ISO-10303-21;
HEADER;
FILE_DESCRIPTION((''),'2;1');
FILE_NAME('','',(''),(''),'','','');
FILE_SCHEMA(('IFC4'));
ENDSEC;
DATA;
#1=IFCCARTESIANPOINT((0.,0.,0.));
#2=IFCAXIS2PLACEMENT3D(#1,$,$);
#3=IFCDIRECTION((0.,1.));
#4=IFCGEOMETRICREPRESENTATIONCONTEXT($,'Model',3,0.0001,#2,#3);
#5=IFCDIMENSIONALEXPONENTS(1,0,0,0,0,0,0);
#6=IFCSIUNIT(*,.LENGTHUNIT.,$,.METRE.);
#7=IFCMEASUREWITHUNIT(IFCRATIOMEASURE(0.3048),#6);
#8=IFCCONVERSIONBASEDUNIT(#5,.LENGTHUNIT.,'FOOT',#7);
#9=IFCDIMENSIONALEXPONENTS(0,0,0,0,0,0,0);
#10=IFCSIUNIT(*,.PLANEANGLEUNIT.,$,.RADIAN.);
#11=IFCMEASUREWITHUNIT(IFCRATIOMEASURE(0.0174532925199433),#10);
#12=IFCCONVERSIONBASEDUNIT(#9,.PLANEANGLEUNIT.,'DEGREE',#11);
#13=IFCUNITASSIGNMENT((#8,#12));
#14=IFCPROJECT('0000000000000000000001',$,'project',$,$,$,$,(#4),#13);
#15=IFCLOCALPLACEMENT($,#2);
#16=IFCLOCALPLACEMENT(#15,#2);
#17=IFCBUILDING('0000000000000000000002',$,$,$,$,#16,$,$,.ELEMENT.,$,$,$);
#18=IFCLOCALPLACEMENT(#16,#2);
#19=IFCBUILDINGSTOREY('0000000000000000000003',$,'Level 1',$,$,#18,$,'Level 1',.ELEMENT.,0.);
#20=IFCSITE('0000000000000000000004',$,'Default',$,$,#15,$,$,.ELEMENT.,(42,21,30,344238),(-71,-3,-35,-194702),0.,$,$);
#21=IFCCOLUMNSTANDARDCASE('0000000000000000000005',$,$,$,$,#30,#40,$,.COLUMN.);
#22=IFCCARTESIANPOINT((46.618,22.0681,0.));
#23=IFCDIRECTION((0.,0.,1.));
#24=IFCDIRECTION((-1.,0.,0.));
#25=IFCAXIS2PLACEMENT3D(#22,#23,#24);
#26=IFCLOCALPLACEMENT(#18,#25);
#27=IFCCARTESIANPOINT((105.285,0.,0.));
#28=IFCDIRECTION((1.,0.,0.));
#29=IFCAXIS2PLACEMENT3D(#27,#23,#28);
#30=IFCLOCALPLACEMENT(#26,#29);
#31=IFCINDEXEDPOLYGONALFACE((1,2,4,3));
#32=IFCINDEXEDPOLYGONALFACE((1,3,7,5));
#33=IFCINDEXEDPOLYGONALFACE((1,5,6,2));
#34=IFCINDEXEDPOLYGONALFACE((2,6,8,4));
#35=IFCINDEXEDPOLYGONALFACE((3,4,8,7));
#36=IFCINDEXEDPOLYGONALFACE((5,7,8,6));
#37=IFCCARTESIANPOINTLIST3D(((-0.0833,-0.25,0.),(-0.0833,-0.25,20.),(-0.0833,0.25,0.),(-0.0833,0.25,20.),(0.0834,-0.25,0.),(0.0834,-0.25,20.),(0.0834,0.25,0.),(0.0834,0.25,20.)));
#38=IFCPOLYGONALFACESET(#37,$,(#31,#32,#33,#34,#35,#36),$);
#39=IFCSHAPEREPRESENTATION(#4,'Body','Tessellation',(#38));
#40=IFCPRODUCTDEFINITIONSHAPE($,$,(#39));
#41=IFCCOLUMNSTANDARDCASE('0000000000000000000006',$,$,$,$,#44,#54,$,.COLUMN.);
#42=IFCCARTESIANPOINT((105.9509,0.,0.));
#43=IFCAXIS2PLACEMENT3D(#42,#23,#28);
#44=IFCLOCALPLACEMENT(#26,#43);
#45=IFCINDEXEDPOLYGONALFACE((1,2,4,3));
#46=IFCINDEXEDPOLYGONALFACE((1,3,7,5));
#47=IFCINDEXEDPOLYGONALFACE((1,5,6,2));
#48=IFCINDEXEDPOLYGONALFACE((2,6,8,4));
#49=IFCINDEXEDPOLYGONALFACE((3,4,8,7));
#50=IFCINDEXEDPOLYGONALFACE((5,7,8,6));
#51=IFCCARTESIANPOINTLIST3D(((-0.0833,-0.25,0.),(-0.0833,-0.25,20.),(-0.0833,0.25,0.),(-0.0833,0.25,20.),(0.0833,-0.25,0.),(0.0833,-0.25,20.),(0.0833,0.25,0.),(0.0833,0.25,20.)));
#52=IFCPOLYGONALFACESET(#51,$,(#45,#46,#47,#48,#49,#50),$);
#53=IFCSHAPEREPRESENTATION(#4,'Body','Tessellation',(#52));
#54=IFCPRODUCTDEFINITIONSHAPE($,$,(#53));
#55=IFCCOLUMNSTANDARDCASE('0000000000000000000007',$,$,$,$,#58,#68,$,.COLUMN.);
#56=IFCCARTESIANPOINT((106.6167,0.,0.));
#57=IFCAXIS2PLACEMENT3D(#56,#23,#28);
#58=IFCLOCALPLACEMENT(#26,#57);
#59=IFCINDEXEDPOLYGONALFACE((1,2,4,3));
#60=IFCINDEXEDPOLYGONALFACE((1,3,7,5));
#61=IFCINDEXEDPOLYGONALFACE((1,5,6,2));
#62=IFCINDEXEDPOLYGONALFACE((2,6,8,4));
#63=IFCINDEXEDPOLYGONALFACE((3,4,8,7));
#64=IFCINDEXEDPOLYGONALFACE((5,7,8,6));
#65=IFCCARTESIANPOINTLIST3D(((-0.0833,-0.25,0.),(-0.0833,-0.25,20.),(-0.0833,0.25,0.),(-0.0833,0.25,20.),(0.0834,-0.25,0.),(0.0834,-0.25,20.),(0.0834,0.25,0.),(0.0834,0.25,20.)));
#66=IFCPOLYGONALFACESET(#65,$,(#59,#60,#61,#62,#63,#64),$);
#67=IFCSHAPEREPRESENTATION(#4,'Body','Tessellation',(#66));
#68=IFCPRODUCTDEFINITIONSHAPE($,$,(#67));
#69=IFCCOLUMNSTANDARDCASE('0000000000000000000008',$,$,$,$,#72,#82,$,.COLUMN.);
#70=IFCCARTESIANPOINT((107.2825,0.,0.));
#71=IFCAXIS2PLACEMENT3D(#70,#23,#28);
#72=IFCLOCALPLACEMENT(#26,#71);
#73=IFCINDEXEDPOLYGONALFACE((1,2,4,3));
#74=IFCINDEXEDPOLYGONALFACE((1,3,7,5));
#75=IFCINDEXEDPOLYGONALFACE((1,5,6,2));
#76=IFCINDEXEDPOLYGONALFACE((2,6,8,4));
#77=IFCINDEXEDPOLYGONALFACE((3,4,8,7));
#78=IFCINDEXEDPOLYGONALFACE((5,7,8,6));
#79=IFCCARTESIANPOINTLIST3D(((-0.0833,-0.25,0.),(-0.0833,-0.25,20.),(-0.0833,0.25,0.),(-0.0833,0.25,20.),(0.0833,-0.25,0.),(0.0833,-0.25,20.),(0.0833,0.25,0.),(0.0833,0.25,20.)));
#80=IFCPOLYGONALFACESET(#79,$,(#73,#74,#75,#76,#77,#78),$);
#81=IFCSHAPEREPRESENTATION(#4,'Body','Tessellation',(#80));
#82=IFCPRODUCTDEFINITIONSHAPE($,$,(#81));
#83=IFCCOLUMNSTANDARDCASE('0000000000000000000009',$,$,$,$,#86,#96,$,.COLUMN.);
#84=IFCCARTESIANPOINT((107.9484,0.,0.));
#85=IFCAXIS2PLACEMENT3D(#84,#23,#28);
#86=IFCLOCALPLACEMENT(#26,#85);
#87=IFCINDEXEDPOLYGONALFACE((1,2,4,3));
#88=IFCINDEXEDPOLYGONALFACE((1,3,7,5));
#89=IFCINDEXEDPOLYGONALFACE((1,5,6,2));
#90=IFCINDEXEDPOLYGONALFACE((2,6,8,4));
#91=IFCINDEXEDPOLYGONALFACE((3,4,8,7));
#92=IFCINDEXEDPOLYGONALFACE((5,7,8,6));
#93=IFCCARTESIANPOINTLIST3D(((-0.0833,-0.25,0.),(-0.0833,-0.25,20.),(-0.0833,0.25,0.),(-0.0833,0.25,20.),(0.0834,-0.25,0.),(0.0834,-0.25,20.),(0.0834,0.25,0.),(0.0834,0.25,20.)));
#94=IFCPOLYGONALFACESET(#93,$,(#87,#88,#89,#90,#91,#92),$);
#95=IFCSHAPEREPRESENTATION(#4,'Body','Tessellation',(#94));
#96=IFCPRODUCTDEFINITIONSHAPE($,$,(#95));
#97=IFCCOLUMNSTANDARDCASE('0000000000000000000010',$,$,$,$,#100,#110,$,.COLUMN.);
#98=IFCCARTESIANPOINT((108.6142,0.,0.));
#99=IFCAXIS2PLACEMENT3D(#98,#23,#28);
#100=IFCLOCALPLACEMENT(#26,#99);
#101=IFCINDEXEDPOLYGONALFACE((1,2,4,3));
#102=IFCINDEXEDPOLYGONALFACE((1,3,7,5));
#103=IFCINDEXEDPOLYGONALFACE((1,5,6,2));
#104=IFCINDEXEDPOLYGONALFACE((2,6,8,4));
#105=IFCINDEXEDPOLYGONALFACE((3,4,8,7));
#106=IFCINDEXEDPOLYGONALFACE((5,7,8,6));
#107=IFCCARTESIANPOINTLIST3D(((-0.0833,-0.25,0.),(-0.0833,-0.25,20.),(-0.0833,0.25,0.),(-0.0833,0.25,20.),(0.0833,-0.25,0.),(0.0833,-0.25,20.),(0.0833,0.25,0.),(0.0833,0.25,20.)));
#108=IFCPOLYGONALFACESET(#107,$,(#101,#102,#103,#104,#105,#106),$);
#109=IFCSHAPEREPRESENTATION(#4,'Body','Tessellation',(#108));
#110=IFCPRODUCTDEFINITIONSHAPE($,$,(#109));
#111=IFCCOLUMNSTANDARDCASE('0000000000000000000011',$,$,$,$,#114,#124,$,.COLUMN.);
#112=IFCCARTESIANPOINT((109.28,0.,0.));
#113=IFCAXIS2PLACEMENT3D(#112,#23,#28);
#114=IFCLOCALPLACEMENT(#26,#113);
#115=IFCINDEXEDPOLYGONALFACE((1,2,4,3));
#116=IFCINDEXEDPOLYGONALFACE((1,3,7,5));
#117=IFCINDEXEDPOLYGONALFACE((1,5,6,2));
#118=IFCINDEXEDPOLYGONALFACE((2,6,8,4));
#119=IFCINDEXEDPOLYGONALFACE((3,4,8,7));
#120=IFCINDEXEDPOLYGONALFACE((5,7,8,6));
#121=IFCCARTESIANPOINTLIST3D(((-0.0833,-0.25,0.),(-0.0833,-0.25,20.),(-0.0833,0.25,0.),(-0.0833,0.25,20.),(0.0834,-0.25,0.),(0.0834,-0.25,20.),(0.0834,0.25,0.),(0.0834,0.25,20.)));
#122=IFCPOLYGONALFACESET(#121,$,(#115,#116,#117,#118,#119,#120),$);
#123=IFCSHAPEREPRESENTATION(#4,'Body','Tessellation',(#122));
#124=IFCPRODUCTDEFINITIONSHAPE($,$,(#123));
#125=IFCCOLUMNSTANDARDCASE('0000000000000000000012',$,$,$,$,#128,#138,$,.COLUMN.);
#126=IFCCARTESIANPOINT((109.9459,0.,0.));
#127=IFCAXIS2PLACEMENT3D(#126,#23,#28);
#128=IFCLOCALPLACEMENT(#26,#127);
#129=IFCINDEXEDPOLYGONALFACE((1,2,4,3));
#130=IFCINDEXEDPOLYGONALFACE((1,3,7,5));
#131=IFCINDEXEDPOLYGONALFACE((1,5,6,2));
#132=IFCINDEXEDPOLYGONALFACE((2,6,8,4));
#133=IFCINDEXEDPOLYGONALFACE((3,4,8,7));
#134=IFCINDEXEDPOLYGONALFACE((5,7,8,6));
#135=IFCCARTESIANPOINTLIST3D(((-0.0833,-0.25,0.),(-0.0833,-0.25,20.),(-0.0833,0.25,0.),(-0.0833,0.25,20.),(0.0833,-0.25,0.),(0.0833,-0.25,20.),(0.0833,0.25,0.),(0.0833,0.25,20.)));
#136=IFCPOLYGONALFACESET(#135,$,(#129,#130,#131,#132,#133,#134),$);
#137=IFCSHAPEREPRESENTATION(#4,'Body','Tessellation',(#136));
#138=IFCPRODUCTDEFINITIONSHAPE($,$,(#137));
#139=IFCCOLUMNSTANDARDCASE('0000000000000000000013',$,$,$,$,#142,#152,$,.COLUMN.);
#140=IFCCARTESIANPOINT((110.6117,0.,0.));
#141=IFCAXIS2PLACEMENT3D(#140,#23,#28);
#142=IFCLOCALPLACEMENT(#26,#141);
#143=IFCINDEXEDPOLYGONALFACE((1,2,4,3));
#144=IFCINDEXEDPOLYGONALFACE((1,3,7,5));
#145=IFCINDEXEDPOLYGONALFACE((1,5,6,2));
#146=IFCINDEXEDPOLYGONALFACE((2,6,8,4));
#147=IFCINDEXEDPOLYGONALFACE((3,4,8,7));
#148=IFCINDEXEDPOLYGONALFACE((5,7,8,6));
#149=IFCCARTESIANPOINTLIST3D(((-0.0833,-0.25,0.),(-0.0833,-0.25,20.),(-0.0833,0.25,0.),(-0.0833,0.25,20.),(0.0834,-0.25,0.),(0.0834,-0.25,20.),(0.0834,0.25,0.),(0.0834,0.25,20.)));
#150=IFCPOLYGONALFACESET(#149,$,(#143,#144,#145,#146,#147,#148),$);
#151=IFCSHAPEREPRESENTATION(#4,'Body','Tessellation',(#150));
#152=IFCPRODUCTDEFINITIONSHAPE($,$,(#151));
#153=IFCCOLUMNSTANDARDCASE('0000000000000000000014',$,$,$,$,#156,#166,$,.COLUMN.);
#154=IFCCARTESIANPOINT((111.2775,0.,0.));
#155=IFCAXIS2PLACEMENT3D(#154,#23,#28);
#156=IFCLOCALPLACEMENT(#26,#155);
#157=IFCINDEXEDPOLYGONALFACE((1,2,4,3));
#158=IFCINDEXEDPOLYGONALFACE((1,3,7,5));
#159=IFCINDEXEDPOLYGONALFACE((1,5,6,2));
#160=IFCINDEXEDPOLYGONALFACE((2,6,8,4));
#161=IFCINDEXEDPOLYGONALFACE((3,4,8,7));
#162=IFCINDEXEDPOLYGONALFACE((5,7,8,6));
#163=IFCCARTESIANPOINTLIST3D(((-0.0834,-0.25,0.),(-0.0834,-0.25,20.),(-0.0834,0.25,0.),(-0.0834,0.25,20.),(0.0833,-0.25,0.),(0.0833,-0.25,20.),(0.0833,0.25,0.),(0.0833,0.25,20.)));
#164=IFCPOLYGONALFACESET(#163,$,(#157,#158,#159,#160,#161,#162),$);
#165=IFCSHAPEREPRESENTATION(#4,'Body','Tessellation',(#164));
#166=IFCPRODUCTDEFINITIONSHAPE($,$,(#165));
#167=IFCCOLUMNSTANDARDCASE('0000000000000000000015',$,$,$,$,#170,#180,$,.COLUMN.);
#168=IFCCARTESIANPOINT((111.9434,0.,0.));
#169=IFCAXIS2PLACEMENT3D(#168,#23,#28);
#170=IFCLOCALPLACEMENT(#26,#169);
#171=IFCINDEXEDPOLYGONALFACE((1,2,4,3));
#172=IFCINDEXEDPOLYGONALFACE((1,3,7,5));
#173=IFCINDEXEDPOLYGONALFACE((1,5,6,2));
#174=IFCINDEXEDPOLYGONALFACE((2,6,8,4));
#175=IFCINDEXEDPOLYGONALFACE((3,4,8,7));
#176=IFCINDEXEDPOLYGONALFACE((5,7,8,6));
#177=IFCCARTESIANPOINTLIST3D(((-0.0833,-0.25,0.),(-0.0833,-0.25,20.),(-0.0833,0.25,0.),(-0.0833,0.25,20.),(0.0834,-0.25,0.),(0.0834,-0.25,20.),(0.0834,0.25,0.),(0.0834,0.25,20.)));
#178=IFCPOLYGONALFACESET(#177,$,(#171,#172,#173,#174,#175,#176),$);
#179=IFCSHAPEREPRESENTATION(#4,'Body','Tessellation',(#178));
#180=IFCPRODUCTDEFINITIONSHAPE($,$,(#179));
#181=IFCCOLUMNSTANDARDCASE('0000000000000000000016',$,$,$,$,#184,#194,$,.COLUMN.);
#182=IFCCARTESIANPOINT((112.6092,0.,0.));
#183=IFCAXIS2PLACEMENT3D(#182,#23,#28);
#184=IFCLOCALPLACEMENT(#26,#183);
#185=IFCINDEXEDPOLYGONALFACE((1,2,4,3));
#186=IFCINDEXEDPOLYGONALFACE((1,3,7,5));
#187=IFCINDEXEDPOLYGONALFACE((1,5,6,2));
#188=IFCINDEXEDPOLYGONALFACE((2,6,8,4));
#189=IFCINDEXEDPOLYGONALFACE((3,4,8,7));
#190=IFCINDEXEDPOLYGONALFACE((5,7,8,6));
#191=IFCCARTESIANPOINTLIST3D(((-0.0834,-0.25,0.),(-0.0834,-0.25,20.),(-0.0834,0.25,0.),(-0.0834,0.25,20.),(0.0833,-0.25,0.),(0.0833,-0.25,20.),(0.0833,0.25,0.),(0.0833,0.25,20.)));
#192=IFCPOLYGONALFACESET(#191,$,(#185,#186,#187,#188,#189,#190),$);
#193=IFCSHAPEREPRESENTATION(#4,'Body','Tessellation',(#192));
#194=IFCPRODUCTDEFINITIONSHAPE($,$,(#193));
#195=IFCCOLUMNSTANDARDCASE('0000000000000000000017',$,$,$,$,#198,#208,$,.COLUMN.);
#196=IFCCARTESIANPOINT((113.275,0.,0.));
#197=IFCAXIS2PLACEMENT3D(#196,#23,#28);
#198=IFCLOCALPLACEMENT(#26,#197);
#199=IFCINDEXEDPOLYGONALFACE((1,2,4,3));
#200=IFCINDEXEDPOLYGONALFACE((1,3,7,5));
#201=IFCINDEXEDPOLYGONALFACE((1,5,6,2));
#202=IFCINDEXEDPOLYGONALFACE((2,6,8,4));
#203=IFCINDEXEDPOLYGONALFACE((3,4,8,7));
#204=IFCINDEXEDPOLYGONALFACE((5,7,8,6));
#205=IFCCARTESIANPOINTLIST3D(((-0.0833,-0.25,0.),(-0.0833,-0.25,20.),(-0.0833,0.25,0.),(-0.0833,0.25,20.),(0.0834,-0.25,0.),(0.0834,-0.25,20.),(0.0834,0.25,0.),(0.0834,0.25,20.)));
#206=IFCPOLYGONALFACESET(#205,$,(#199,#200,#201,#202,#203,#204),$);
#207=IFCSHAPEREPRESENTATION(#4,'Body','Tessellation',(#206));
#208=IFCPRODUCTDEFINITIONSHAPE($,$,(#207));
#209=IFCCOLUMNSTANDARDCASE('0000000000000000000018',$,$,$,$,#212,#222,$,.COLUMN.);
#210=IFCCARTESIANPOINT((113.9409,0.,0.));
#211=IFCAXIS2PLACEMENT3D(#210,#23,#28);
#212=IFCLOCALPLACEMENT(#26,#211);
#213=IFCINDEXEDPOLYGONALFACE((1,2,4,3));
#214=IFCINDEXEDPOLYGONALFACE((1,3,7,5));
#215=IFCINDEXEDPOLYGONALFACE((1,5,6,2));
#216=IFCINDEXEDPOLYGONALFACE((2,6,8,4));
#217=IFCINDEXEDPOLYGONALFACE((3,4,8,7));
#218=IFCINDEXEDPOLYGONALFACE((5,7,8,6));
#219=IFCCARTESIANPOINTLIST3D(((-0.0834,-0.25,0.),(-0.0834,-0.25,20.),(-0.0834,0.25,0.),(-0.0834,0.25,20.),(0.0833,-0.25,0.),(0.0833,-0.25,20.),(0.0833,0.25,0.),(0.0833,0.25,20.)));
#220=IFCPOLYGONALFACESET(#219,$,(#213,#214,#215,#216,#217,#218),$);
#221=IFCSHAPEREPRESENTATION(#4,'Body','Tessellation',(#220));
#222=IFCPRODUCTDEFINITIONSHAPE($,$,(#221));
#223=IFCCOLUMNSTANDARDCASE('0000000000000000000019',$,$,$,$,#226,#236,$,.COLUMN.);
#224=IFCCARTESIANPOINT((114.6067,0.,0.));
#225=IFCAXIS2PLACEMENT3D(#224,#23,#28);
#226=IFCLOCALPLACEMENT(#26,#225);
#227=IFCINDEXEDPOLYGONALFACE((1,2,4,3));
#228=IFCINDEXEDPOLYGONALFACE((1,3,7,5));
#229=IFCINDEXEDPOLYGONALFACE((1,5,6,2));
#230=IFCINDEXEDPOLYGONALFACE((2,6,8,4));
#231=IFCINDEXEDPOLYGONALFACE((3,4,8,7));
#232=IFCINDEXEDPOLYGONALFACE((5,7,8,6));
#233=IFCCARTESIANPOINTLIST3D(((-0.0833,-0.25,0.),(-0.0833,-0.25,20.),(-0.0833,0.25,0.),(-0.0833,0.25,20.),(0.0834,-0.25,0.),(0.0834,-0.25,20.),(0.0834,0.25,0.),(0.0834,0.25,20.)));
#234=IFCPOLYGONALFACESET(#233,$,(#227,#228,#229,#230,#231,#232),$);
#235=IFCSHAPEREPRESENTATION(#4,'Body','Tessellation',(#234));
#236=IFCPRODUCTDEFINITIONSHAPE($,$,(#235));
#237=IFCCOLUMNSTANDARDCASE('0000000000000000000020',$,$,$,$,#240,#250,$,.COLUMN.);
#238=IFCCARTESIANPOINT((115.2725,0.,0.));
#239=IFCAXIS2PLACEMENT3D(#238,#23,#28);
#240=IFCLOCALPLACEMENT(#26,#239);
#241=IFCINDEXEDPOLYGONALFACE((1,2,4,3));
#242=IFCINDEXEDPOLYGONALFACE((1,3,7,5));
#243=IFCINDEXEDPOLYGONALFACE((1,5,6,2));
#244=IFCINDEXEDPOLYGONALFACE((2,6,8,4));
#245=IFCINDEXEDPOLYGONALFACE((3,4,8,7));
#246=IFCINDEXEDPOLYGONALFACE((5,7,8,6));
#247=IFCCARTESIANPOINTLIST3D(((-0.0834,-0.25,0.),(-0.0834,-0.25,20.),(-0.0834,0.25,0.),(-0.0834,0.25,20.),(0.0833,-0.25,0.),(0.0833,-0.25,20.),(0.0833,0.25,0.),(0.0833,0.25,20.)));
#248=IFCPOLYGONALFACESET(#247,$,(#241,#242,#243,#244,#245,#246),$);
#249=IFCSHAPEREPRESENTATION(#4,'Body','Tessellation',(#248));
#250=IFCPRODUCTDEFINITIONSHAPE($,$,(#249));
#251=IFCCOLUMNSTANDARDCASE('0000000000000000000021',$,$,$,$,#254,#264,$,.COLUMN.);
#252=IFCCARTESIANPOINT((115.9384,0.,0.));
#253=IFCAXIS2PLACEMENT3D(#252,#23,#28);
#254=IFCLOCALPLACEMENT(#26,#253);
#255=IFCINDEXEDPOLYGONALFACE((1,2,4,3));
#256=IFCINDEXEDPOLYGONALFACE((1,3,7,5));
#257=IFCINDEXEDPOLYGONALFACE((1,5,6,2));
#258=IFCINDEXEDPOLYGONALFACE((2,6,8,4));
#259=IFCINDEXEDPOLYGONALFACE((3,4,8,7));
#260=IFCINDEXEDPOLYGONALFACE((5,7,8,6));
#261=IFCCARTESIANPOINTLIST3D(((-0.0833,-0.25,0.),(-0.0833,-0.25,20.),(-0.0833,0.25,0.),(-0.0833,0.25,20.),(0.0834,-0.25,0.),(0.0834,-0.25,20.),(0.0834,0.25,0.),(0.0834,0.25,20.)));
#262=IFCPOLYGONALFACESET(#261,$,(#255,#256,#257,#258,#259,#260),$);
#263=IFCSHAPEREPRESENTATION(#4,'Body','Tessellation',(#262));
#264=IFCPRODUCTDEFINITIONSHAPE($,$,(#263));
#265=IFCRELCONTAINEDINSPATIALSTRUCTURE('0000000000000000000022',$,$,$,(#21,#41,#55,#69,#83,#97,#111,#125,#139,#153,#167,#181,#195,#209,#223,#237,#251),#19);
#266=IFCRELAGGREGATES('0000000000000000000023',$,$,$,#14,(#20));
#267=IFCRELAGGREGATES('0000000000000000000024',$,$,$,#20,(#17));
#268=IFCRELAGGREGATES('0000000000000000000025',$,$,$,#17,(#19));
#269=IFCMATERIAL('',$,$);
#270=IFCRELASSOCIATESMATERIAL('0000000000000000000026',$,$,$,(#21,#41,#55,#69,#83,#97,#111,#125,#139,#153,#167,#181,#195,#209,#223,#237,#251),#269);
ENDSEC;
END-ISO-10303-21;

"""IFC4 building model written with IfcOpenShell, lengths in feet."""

from ifc_helpers import new_model, entity, si_unit, converted_unit, direction, frame, origin, place, context, project, spatial, rectangle, extrude, material, element, save


model = new_model("IFC4")

# Units and contexts
model_context = context("Model", 3, precision=0.0001, world=origin(), true_north=direction((0.0, 1.0)))
ifc_project = project(units=[converted_unit("LENGTHUNIT", "FOOT", entity("IfcRatioMeasure", 0.3048), si_unit("LENGTHUNIT", "METRE"), dimensions=[1, 0, 0, 0, 0, 0, 0]), converted_unit("PLANEANGLEUNIT", "DEGREE", entity("IfcRatioMeasure", 0.0174532925199433), si_unit("PLANEANGLEUNIT", "RADIAN"), dimensions=[0, 0, 0, 0, 0, 0, 0])], contexts=[model_context])

# Site, building, storey
site_placement = place(None, origin())
site = spatial("IfcSite", under=ifc_project, at=site_placement, Name="Default", CompositionType="ELEMENT", RefLatitude=(42, 21, 30, 344238), RefLongitude=(-71, -3, -35, -194702), RefElevation=0.0)
building_placement = place(site_placement, origin())
building = spatial("IfcBuilding", under=site, at=building_placement, CompositionType="ELEMENT")
storey_placement = place(building_placement, origin())
storey = spatial("IfcBuildingStorey", under=building, at=storey_placement, Name="Level 1", LongName="Level 1", CompositionType="ELEMENT", Elevation=0.0)

# Columns
ifc_material_1 = material(Name="")
placement_1 = place(storey_placement, frame((46.618, 22.0681, 0.0), z_axis=(0.0, 0.0, 1.0), x_axis=(-1.0, 0.0, 0.0)))
for number, where, z_axis, x_axis in (
    (1, (105.285, 0.0, 0.0), (0.0, 0.0, 1.0), (1.0, 0.0, 0.0)),
    (2, (105.9509, 0.0, 0.0), (0.0, 0.0, 1.0), (1.0, 0.0, 0.0)),
    (3, (106.6167, 0.0, 0.0), (0.0, 0.0, 1.0), (1.0, 0.0, 0.0)),
    (4, (107.2825, 0.0, 0.0), (0.0, 0.0, 1.0), (1.0, 0.0, 0.0)),
    (5, (107.9484, 0.0, 0.0), (0.0, 0.0, 1.0), (1.0, 0.0, 0.0)),
    (6, (108.6142, 0.0, 0.0), (0.0, 0.0, 1.0), (1.0, 0.0, 0.0)),
    (7, (109.28, 0.0, 0.0), (0.0, 0.0, 1.0), (1.0, 0.0, 0.0)),
    (8, (109.9459, 0.0, 0.0), (0.0, 0.0, 1.0), (1.0, 0.0, 0.0)),
    (9, (110.6117, 0.0, 0.0), (0.0, 0.0, 1.0), (1.0, 0.0, 0.0)),
    (10, (111.2775, 0.0, 0.0), (0.0, 0.0, 1.0), (1.0, 0.0, 0.0)),
    (11, (111.9434, 0.0, 0.0), (0.0, 0.0, 1.0), (1.0, 0.0, 0.0)),
    (12, (112.6092, 0.0, 0.0), (0.0, 0.0, 1.0), (1.0, 0.0, 0.0)),
    (13, (113.275, 0.0, 0.0), (0.0, 0.0, 1.0), (1.0, 0.0, 0.0)),
    (14, (113.9409, 0.0, 0.0), (0.0, 0.0, 1.0), (1.0, 0.0, 0.0)),
    (15, (114.6067, 0.0, 0.0), (0.0, 0.0, 1.0), (1.0, 0.0, 0.0)),
    (16, (115.2725, 0.0, 0.0), (0.0, 0.0, 1.0), (1.0, 0.0, 0.0)),
    (17, (115.9384, 0.0, 0.0), (0.0, 0.0, 1.0), (1.0, 0.0, 0.0)),
):
    element("IfcColumnStandardCase", number, at=place(placement_1, frame(where, z_axis=z_axis, x_axis=x_axis)), inside=storey, material=ifc_material_1, PredefinedType="COLUMN", context=model_context, shape_type="SweptSolid", body=[
        extrude(rectangle(XDim=0.1667, YDim=0.5), origin(), (0.0, 0.0, 1.0), 20.0),
    ])

save(model, "model.ifc")
